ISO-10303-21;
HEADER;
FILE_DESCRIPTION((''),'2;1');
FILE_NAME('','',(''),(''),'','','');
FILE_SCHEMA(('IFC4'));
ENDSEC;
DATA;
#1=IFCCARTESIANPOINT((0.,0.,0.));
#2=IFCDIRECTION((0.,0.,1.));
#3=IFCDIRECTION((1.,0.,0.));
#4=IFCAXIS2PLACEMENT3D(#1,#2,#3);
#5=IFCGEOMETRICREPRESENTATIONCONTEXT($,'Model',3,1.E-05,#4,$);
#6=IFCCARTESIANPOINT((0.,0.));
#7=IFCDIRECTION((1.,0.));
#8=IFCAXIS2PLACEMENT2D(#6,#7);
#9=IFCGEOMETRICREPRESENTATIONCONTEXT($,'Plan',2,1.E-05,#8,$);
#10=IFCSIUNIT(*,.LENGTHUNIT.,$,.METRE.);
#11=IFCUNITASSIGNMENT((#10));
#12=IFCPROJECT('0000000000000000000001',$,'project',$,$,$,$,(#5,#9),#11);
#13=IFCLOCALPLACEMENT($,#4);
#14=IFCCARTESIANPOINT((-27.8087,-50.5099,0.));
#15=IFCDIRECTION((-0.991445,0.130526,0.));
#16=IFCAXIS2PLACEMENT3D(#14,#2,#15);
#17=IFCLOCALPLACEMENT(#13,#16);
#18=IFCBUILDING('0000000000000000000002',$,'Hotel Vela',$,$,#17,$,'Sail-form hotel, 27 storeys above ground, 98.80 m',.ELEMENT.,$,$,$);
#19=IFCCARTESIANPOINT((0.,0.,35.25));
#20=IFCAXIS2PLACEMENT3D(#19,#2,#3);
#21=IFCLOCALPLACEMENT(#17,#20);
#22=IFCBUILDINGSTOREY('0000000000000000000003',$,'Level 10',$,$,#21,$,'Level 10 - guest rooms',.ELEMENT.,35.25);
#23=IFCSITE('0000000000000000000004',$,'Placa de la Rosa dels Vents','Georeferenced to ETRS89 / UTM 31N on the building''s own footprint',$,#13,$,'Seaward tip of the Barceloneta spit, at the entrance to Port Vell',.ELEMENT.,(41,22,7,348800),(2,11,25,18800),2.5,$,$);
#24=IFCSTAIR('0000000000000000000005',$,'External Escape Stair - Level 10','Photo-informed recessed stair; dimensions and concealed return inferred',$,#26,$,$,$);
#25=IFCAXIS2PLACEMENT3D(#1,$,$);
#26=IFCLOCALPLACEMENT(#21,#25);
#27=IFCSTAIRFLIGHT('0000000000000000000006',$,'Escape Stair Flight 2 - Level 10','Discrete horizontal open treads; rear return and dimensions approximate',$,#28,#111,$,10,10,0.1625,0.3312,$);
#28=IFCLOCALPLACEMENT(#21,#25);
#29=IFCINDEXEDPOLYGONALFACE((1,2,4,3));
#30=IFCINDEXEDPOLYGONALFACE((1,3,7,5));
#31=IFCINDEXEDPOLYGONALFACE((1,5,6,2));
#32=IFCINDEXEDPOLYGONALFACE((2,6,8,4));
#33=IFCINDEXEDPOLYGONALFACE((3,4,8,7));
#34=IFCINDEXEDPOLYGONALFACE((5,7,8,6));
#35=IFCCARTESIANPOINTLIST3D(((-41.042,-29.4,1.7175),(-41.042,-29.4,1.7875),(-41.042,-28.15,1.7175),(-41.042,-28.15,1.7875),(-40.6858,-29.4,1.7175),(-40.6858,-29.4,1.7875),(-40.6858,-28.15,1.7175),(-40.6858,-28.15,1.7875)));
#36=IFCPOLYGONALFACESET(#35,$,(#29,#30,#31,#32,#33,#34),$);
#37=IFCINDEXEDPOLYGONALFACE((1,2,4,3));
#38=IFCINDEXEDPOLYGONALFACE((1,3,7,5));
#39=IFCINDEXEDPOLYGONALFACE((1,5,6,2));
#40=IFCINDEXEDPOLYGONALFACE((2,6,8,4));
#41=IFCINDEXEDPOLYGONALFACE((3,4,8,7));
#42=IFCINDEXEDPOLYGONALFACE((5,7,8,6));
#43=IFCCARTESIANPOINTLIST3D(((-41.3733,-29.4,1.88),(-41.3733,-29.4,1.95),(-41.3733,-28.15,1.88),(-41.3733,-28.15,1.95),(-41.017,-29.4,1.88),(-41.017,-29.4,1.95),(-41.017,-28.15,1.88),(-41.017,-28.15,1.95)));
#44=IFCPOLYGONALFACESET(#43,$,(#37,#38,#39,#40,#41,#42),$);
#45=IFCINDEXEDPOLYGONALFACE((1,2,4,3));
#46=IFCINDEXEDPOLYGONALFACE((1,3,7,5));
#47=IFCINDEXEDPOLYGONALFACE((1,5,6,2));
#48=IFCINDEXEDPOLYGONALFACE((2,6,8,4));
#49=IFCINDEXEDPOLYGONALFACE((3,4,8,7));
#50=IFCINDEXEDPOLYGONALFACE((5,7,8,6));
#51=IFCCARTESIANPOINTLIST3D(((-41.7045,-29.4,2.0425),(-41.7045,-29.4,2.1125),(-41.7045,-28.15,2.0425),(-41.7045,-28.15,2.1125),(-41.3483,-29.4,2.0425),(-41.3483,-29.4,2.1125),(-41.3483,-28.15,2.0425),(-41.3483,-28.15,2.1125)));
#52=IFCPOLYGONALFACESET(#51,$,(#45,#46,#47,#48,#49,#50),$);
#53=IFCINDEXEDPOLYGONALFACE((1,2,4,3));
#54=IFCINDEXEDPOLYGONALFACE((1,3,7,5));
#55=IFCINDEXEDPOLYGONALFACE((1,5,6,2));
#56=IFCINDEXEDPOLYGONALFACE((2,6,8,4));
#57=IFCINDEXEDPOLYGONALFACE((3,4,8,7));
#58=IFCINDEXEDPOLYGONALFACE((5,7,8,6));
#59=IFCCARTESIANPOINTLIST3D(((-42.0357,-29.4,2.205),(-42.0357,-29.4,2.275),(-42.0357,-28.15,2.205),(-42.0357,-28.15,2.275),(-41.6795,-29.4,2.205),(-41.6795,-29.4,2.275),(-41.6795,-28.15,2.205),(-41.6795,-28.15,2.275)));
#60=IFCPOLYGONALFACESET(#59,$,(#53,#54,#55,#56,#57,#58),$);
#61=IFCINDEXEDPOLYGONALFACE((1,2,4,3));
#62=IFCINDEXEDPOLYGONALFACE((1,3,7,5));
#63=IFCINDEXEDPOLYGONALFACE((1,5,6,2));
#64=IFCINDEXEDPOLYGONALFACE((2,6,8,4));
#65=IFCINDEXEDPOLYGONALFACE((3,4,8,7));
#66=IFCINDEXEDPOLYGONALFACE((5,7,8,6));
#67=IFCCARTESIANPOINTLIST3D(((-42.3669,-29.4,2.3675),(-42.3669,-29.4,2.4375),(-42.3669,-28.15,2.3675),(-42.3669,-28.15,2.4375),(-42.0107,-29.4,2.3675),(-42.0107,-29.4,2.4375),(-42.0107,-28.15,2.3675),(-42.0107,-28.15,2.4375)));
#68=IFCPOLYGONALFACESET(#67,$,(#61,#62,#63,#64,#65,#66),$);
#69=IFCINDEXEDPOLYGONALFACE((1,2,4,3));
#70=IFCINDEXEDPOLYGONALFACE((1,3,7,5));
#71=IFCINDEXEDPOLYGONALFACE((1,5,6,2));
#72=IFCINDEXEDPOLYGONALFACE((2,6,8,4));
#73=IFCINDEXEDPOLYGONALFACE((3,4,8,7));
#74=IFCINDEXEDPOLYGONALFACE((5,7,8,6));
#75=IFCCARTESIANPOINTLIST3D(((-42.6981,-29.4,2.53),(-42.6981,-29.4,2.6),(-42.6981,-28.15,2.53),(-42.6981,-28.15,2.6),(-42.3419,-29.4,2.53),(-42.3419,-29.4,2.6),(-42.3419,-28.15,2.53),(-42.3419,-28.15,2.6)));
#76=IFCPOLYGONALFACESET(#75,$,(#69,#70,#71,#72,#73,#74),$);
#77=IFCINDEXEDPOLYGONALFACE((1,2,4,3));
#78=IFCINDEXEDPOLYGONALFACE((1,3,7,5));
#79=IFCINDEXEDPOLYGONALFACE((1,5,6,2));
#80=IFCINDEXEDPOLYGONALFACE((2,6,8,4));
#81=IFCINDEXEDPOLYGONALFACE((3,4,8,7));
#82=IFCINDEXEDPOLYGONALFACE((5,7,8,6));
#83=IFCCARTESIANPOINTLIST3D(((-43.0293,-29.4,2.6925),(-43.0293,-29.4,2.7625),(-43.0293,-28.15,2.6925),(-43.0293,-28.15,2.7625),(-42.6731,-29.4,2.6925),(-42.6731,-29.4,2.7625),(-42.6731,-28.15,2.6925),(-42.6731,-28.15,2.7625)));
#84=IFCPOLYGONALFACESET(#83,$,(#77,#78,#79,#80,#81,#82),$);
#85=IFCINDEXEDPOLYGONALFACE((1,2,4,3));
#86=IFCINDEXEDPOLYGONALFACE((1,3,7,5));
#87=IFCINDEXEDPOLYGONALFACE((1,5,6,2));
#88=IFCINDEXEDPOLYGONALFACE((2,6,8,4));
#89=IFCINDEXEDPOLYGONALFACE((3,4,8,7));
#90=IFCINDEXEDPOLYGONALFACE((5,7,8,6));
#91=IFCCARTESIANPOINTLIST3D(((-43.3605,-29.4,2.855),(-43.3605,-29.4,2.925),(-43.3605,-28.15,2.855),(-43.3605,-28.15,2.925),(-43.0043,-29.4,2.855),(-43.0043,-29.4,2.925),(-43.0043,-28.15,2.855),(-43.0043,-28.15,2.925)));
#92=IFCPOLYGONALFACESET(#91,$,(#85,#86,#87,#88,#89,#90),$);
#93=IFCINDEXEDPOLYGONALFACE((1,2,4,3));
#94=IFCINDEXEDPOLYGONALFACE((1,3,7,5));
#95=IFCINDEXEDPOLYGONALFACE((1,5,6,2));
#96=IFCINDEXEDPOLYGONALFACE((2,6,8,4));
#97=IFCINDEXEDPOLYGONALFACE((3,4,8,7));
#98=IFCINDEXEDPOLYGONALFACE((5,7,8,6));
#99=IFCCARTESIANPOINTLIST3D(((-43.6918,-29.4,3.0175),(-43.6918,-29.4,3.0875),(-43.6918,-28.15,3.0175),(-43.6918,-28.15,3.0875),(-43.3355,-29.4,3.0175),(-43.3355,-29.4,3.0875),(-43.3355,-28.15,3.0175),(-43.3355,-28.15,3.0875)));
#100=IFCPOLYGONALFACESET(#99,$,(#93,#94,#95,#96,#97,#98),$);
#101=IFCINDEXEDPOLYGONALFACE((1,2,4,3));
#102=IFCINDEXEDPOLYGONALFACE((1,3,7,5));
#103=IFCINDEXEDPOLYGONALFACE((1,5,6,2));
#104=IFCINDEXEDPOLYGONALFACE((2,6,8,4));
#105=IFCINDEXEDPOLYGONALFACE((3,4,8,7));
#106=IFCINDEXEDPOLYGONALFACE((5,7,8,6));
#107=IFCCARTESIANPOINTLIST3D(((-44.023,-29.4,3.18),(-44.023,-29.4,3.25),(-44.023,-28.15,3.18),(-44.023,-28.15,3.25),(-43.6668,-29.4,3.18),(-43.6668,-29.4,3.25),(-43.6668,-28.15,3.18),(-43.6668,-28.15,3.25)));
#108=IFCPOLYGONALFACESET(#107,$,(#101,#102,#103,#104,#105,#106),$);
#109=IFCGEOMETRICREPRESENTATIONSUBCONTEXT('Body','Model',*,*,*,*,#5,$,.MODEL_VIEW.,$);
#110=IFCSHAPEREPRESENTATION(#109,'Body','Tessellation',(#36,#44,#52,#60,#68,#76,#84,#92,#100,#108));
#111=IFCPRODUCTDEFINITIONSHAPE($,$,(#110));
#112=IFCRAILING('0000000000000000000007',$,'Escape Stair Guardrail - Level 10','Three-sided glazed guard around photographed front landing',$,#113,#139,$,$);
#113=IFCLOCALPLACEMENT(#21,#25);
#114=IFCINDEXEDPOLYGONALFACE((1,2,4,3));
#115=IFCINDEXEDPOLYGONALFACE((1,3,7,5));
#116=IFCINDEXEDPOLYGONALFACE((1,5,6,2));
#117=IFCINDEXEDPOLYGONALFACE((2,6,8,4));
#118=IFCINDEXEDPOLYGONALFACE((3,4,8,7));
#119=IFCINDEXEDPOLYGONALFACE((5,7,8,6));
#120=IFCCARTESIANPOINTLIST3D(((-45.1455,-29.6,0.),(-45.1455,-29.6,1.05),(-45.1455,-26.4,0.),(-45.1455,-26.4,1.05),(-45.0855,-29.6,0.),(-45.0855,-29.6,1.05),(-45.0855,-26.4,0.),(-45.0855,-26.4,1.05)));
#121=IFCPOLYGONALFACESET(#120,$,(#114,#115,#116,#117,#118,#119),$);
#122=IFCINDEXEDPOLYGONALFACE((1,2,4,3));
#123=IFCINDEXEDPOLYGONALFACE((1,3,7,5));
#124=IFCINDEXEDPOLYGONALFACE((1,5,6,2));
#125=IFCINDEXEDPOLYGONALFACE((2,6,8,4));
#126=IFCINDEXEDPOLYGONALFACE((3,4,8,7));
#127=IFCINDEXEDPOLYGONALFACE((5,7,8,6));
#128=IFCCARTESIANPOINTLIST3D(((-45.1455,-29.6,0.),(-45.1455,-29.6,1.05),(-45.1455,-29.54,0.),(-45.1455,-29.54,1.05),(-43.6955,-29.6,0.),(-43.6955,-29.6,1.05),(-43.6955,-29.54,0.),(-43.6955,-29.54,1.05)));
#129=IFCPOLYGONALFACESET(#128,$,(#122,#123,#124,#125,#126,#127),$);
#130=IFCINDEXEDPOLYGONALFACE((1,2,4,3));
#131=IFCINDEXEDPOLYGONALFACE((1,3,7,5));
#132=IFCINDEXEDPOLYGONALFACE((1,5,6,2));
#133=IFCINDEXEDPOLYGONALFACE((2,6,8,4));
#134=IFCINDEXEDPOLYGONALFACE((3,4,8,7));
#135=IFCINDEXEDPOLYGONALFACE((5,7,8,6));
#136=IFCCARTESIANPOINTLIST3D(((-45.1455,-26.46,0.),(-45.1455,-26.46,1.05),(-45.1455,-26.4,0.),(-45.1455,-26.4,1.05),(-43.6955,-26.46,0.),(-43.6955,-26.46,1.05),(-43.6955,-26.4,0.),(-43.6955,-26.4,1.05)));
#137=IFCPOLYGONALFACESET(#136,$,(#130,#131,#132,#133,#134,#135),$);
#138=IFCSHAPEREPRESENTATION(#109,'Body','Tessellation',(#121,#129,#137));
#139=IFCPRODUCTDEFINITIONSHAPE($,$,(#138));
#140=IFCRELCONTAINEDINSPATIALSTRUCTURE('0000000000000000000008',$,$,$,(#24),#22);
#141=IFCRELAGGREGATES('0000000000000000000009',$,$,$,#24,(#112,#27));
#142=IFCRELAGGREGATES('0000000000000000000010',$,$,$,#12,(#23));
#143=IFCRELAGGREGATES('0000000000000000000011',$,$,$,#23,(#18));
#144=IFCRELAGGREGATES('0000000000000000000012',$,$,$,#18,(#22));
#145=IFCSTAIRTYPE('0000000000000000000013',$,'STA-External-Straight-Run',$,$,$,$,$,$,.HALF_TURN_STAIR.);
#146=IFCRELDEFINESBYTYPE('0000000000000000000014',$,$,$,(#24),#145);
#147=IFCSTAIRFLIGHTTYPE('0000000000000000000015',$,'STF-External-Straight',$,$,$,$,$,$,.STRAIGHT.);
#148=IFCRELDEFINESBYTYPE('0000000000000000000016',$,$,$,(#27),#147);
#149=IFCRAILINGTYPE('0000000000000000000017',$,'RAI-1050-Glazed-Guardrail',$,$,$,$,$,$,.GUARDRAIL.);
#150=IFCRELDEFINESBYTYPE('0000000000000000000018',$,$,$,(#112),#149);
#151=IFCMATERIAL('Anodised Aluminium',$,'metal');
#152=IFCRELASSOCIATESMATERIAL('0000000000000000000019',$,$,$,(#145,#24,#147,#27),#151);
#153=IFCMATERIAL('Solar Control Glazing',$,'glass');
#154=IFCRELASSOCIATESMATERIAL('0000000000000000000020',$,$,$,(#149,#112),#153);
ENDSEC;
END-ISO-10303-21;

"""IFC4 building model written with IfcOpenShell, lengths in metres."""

from ifc_helpers import new_model, si_unit, frame, origin_with_axes, origin_2d_with_axis, place, context, subcontext, project, spatial, line, indexed_curve, outline, extrude, material, type_object, element, aggregate, save


model = new_model("IFC4")

# Units and contexts
model_context = context("Model", 3, precision=1e-05, world=origin_with_axes())
plan_context = context("Plan", 2, precision=1e-05, world=origin_2d_with_axis())
body_context = subcontext(model_context, "Body", "Model", "MODEL_VIEW")
ifc_project = project(units=[si_unit("LENGTHUNIT", "METRE")], contexts=[model_context, plan_context])

# Site, building, storey
site_placement = place(None, origin_with_axes())
site = spatial("IfcSite", under=ifc_project, at=site_placement, Name="Placa de la Rosa dels Vents", Description="Georeferenced to ETRS89 / UTM 31N on the building's own footprint", LongName="Seaward tip of the Barceloneta spit, at the entrance to Port Vell", CompositionType="ELEMENT", RefLatitude=(41, 22, 7, 348800), RefLongitude=(2, 11, 25, 18800), RefElevation=2.5)
building_placement = place(site_placement, frame((-27.8087, -50.5099, 0.0), z_axis=(0.0, 0.0, 1.0), x_axis=(-0.991445, 0.130526, 0.0)))
building = spatial("IfcBuilding", under=site, at=building_placement, Name="Hotel Vela", LongName="Sail-form hotel, 27 storeys above ground, 98.80 m", CompositionType="ELEMENT")
storey_placement = place(building_placement, frame((0.0, 0.0, 35.25), z_axis=(0.0, 0.0, 1.0), x_axis=(1.0, 0.0, 0.0)))
storey = spatial("IfcBuildingStorey", under=building, at=storey_placement, Name="Level 10", LongName="Level 10 - guest rooms", CompositionType="ELEMENT", Elevation=35.25)

# Stair
ifc_material_1 = material(Name="Anodised Aluminium", Category="metal")
stair_type = type_object("IfcStairType", Name="STA-External-Straight-Run", PredefinedType="HALF_TURN_STAIR", material=ifc_material_1)
stair_placement = place(storey_placement, frame((0.0, 0.0, -35.25), z_axis=(0.0, 0.0, 1.0), x_axis=(1.0, 0.0, 0.0)))
stair = element("IfcStair", 1, at=stair_placement, inside=storey, type_object=stair_type, material=ifc_material_1, Name="External Escape Stair - Level 10", Description="Photo-informed recessed stair; dimensions and concealed return inferred")

# Stair flight
stair_flight_type = type_object("IfcStairFlightType", Name="STF-External-Straight", PredefinedType="STRAIGHT", material=ifc_material_1)
stair_flight_1_placement = place(stair_placement, origin_with_axes())
stair_flight_1 = element("IfcStairFlight", 2, at=stair_flight_1_placement, type_object=stair_flight_type, material=ifc_material_1, Name="Escape Stair Flight 2 - Level 10", Description="Discrete horizontal open treads; rear return and dimensions approximate", NumberOfRisers=10, NumberOfTreads=10, RiserHeight=0.1625, TreadLength=0.3312, context=body_context, shape_type="SweptSolid", body=[
    extrude(outline(indexed_curve([(0.0, 0.0), (0.3562, 0.0), (0.3562, 1.25), (0.0, 1.25)], segments=[line(1, 2, 3, 4, 1)])), frame((-41.042, -29.4, 36.9675), z_axis=(0.0, 0.0, 1.0), x_axis=(1.0, 0.0, 0.0)), (0.0, 0.0, 1.0), 0.07),
    extrude(outline(indexed_curve([(0.0, 0.0), (0.3562, 0.0), (0.3562, 1.25), (0.0, 1.25)], segments=[line(1, 2, 3, 4, 1)])), frame((-41.3733, -29.4, 37.13), z_axis=(0.0, 0.0, 1.0), x_axis=(1.0, 0.0, 0.0)), (0.0, 0.0, 1.0), 0.07),
    extrude(outline(indexed_curve([(0.0, 0.0), (0.3562, 0.0), (0.3562, 1.25), (0.0, 1.25)], segments=[line(1, 2, 3, 4, 1)])), frame((-41.7045, -29.4, 37.2925), z_axis=(0.0, 0.0, 1.0), x_axis=(1.0, 0.0, 0.0)), (0.0, 0.0, 1.0), 0.07),
    extrude(outline(indexed_curve([(0.0, 0.0), (0.3562, 0.0), (0.3562, 1.25), (0.0, 1.25)], segments=[line(1, 2, 3, 4, 1)])), frame((-42.0357, -29.4, 37.455), z_axis=(0.0, 0.0, 1.0), x_axis=(1.0, 0.0, 0.0)), (0.0, 0.0, 1.0), 0.07),
    extrude(outline(indexed_curve([(0.0, 0.0), (0.3562, 0.0), (0.3562, 1.25), (0.0, 1.25)], segments=[line(1, 2, 3, 4, 1)])), frame((-42.3669, -29.4, 37.6175), z_axis=(0.0, 0.0, 1.0), x_axis=(1.0, 0.0, 0.0)), (0.0, 0.0, 1.0), 0.07),
    extrude(outline(indexed_curve([(0.0, 0.0), (0.3562, 0.0), (0.3562, 1.25), (0.0, 1.25)], segments=[line(1, 2, 3, 4, 1)])), frame((-42.6981, -29.4, 37.78), z_axis=(0.0, 0.0, 1.0), x_axis=(1.0, 0.0, 0.0)), (0.0, 0.0, 1.0), 0.07),
    extrude(outline(indexed_curve([(0.0, 0.0), (0.3562, 0.0), (0.3562, 1.25), (0.0, 1.25)], segments=[line(1, 2, 3, 4, 1)])), frame((-43.0293, -29.4, 37.9425), z_axis=(0.0, 0.0, 1.0), x_axis=(1.0, 0.0, 0.0)), (0.0, 0.0, 1.0), 0.07),
    extrude(outline(indexed_curve([(0.0, 0.0), (0.3562, 0.0), (0.3562, 1.25), (0.0, 1.25)], segments=[line(1, 2, 3, 4, 1)])), frame((-43.3605, -29.4, 38.105), z_axis=(0.0, 0.0, 1.0), x_axis=(1.0, 0.0, 0.0)), (0.0, 0.0, 1.0), 0.07),
    extrude(outline(indexed_curve([(0.0, 0.0), (0.3562, 0.0), (0.3562, 1.25), (0.0, 1.25)], segments=[line(1, 2, 3, 4, 1)])), frame((-43.6918, -29.4, 38.2675), z_axis=(0.0, 0.0, 1.0), x_axis=(1.0, 0.0, 0.0)), (0.0, 0.0, 1.0), 0.07),
    extrude(outline(indexed_curve([(0.0, 0.0), (0.3562, 0.0), (0.3562, 1.25), (0.0, 1.25)], segments=[line(1, 2, 3, 4, 1)])), frame((-44.023, -29.4, 38.43), z_axis=(0.0, 0.0, 1.0), x_axis=(1.0, 0.0, 0.0)), (0.0, 0.0, 1.0), 0.07),
])

# Railing
ifc_material_2 = material(Name="Solar Control Glazing", Category="glass")
railing_type = type_object("IfcRailingType", Name="RAI-1050-Glazed-Guardrail", PredefinedType="GUARDRAIL", material=ifc_material_2)
railing_placement = place(stair_placement, origin_with_axes())
railing = element("IfcRailing", 3, at=railing_placement, type_object=railing_type, material=ifc_material_2, Name="Escape Stair Guardrail - Level 10", Description="Three-sided glazed guard around photographed front landing", context=body_context, shape_type="SweptSolid", body=[
    extrude(outline(indexed_curve([(0.0, 0.0), (0.06, 0.0), (0.06, 3.2), (0.0, 3.2)], segments=[line(1, 2, 3, 4, 1)])), frame((-45.1455, -29.6, 35.25), z_axis=(0.0, 0.0, 1.0), x_axis=(1.0, 0.0, 0.0)), (0.0, 0.0, 1.0), 1.05),
    extrude(outline(indexed_curve([(0.0, 0.0), (1.45, 0.0), (1.45, 0.06), (0.0, 0.06)], segments=[line(1, 2, 3, 4, 1)])), frame((-45.1455, -29.6, 35.25), z_axis=(0.0, 0.0, 1.0), x_axis=(1.0, 0.0, 0.0)), (0.0, 0.0, 1.0), 1.05),
    extrude(outline(indexed_curve([(0.0, 0.0), (1.45, 0.0), (1.45, 0.06), (0.0, 0.06)], segments=[line(1, 2, 3, 4, 1)])), frame((-45.1455, -26.46, 35.25), z_axis=(0.0, 0.0, 1.0), x_axis=(1.0, 0.0, 0.0)), (0.0, 0.0, 1.0), 1.05),
])
aggregate(stair, [railing, stair_flight_1])

save(model, "model.ifc")
